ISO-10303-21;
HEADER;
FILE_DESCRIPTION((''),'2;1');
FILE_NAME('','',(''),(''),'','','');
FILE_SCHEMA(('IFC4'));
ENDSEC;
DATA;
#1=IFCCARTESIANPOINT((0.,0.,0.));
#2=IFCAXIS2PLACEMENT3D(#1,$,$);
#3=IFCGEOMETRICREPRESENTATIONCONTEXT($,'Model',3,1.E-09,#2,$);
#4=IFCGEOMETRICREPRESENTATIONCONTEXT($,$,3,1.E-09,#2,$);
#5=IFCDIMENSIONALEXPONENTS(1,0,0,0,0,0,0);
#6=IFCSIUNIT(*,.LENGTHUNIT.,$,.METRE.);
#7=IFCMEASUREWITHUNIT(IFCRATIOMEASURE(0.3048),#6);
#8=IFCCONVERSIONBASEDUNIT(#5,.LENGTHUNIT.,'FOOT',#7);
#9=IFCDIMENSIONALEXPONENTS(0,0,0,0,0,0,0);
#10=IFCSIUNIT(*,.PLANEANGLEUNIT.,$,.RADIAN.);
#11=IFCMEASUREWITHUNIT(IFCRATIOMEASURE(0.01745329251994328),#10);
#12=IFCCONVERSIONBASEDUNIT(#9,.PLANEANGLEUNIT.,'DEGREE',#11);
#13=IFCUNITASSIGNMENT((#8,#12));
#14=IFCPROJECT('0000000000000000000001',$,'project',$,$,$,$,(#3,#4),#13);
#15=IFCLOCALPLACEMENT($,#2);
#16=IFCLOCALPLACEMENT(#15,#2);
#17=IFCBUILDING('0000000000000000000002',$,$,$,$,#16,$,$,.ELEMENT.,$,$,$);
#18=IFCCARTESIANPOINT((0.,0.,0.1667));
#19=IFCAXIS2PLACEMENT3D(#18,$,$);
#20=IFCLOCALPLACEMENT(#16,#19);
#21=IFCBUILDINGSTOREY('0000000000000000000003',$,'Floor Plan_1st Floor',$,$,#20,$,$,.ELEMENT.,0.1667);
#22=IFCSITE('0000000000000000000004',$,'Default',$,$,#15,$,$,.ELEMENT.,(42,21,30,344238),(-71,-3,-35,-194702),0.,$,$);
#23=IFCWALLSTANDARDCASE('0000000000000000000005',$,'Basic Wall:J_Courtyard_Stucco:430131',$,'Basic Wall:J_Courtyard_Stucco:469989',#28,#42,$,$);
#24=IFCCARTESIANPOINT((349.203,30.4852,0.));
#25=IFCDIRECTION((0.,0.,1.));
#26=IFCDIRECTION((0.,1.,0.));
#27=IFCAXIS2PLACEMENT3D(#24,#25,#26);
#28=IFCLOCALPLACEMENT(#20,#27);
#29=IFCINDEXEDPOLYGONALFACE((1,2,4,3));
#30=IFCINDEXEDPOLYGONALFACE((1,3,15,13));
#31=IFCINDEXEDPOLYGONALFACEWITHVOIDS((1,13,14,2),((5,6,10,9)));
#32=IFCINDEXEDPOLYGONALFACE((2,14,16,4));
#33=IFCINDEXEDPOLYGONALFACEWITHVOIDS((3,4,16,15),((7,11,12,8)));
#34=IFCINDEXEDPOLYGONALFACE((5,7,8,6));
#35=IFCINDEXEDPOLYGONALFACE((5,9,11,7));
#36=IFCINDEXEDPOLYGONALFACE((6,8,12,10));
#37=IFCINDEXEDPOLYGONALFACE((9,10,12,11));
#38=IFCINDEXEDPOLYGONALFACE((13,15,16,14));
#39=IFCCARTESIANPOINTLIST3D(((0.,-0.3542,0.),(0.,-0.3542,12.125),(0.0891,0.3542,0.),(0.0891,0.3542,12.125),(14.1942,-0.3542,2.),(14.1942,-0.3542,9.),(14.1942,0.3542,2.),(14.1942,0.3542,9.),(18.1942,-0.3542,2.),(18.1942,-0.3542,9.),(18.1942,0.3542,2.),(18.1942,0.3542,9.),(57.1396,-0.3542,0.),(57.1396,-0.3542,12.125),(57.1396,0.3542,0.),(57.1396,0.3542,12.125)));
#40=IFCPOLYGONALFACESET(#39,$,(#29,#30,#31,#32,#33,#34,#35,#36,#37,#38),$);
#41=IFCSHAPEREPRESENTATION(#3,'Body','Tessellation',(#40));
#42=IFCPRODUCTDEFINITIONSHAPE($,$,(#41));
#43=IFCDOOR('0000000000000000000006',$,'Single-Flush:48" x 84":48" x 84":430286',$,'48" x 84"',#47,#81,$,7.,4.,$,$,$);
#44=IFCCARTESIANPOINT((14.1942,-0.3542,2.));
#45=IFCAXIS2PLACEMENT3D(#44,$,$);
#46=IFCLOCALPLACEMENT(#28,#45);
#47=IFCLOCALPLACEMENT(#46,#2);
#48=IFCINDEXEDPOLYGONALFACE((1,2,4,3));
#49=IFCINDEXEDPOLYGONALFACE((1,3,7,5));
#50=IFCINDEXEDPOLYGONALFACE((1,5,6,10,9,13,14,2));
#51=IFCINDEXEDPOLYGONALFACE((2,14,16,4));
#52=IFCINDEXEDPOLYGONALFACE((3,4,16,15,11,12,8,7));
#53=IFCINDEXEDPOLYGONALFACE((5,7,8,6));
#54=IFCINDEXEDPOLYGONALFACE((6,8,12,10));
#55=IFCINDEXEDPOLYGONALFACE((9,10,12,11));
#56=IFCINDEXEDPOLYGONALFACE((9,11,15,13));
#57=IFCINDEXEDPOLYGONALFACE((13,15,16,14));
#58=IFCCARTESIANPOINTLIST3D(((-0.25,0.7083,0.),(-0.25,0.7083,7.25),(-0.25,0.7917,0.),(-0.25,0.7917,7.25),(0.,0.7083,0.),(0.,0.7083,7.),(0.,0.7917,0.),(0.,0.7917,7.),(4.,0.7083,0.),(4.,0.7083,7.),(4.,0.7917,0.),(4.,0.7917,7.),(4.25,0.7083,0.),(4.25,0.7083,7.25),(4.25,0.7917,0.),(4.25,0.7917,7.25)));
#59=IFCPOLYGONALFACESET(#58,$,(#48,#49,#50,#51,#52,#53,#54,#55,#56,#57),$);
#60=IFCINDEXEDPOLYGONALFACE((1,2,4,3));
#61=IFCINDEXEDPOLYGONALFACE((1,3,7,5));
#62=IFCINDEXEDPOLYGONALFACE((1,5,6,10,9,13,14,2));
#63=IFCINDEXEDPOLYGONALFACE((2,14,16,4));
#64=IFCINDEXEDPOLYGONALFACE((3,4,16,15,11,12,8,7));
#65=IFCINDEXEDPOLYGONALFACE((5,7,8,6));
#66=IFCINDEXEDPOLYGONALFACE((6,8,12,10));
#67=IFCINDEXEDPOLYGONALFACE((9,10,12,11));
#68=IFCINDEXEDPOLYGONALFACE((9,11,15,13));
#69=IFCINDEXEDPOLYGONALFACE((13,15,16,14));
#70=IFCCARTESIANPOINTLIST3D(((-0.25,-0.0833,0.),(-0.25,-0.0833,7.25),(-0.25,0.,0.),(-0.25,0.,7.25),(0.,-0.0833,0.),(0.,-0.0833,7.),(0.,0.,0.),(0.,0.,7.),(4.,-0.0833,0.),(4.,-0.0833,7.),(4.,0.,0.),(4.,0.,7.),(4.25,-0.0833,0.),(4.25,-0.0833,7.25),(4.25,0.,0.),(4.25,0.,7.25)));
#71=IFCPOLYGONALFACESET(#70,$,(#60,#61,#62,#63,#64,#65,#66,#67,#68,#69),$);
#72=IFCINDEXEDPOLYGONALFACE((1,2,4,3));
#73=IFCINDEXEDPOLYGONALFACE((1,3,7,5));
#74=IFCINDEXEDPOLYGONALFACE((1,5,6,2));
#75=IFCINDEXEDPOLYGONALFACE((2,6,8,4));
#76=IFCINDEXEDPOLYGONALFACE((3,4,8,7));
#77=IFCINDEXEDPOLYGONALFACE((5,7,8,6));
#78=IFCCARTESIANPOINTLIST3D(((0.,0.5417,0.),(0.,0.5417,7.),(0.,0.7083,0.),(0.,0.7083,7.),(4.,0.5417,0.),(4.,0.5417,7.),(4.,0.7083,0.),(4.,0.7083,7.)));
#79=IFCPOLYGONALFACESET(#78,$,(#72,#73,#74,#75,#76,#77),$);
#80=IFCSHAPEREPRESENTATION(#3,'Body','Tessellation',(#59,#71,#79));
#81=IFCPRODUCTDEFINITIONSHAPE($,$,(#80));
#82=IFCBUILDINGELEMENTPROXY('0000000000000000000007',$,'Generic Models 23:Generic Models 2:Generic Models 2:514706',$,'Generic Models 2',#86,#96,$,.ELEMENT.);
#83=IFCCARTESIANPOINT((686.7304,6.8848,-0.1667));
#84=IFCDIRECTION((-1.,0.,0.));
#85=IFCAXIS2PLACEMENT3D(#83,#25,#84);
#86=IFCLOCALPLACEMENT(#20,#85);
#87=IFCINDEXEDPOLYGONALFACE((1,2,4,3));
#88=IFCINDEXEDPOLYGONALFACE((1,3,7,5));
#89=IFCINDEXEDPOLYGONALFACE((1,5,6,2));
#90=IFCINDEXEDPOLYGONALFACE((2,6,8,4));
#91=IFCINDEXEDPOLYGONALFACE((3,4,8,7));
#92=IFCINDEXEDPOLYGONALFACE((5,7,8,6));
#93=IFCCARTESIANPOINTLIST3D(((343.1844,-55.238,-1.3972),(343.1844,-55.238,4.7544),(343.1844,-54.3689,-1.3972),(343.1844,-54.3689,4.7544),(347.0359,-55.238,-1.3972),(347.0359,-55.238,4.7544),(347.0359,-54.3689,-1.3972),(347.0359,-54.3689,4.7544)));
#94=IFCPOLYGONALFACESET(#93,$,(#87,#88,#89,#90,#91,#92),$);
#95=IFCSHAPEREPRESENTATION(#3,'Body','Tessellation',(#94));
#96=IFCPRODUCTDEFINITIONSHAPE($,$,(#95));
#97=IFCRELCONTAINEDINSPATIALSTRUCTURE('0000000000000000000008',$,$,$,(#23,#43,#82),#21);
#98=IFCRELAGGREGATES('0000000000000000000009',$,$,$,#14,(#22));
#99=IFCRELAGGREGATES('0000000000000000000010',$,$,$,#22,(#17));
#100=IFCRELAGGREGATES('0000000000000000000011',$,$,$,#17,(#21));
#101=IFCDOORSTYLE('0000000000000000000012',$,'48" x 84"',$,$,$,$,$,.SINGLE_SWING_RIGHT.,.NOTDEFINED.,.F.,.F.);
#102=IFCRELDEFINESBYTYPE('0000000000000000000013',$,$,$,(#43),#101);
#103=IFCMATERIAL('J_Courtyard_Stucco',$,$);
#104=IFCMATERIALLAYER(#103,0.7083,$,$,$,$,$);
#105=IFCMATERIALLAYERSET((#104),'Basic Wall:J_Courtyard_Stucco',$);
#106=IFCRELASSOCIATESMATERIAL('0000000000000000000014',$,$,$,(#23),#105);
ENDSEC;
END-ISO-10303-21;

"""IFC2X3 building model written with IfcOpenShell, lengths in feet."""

from ifc_helpers import new_model, entity, si_unit, converted_unit, frame, frame_2d, origin, origin_2d_with_axis, place, context, project, spatial, polyline, rectangle, outline, extrude, clip, halfspace, source, transform, mapped, material, layer, layer_set, layer_usage, type_object, type_shapes, element, fill, save


model = new_model("IFC2X3")

# Units and contexts
model_context = context("Model", 3, precision=1e-09, world=origin())
context_of_model = context(None, 3, precision=1e-09, world=origin())
ifc_project = project(units=[converted_unit("LENGTHUNIT", "FOOT", entity("IfcRatioMeasure", 0.3048), si_unit("LENGTHUNIT", "METRE"), dimensions=[1, 0, 0, 0, 0, 0, 0]), converted_unit("PLANEANGLEUNIT", "DEGREE", entity("IfcRatioMeasure", 0.01745329251994328), si_unit("PLANEANGLEUNIT", "RADIAN"), dimensions=[0, 0, 0, 0, 0, 0, 0])], contexts=[model_context, context_of_model])

# Site, building, storey
site_placement = place(None, origin())
site = spatial("IfcSite", under=ifc_project, at=site_placement, Name="Default", CompositionType="ELEMENT", RefLatitude=(42, 21, 30, 344238), RefLongitude=(-71, -3, -35, -194702), RefElevation=0.0)
building_placement = place(site_placement, origin())
building = spatial("IfcBuilding", under=site, at=building_placement, CompositionType="ELEMENT")
storey_placement = place(building_placement, frame((0.0, 0.0, 0.1667)))
storey = spatial("IfcBuildingStorey", under=building, at=storey_placement, Name="Floor Plan_1st Floor", CompositionType="ELEMENT", Elevation=0.1667)

# Shared definitions
ifc_material_1 = material(Name="J_Courtyard_Stucco")
ifc_layer_1 = layer(ifc_material_1, 0.7083)
ifc_layer_set_1 = layer_set([ifc_layer_1], Name="Basic Wall:J_Courtyard_Stucco")

# Wall, opening, door
ifc_layer_usage_1 = layer_usage(ifc_layer_set_1, "AXIS2", "NEGATIVE", 0.3542)
wall_1_placement = place(storey_placement, frame((349.203, 30.4852, 0.0), z_axis=(0.0, 0.0, 1.0), x_axis=(0.0, 1.0, 0.0)))
wall_1 = element("IfcWallStandardCase", 1, at=wall_1_placement, inside=storey, material=ifc_layer_usage_1, Name="Basic Wall:J_Courtyard_Stucco:430131", ObjectType="Basic Wall:J_Courtyard_Stucco:469989", context=model_context, shape_type="Clipping", body=[
    clip(extrude(outline(polyline([(57.1396, -0.3542), (57.1396, 0.3542), (0.0891, 0.3542), (0.0, -0.3542), (57.1396, -0.3542)])), origin(), (0.0, 0.0, 1.0), 12.125), halfspace(origin(), True)),
])
opening_1_placement = place(wall_1_placement, frame((14.1942, -0.3542, 2.0)))
opening_1 = element("IfcOpeningElement", 2, at=opening_1_placement, cuts=wall_1, ObjectType="Opening", context=model_context, shape_type="SweptSolid", body=[
    extrude(rectangle(XDim=4.0, YDim=7.0, at=frame_2d((3.5, 2.0), x_axis=(0.0, 1.0))), frame((0.0, 0.0, 0.0), z_axis=(0.0, 1.0, 0.0), x_axis=(0.0, 0.0, 1.0)), (0.0, 0.0, 1.0), 0.7083),
])
door_style_1 = type_object("IfcDoorStyle", Name="48\" x 84\"", ConstructionType="NOTDEFINED", OperationType="SINGLE_SWING_RIGHT", ParameterTakesPrecedence=False, Sizeable=False)
shared_shape_1 = source(origin(), model_context, "Body", "SweptSolid", [
    extrude(outline(polyline([(-2.25, -3.6875), (2.25, -3.6875), (2.25, 3.5625), (2.0, 3.5625), (2.0, -3.4375), (-2.0, -3.4375), (-2.0, 3.5625), (-2.25, 3.5625), (-2.25, -3.6875)])), frame((2.0, 0.7083, 3.5625), z_axis=(0.0, 1.0, 0.0), x_axis=(1.0, 0.0, 0.0)), (0.0, 0.0, 1.0), 0.0833),
    extrude(outline(polyline([(-3.6875, -2.25), (3.5625, -2.25), (3.5625, -2.0), (-3.4375, -2.0), (-3.4375, 2.0), (3.5625, 2.0), (3.5625, 2.25), (-3.6875, 2.25), (-3.6875, -2.25)])), frame((2.0, -0.0833, 3.5625), z_axis=(0.0, 1.0, 0.0), x_axis=(0.0, 0.0, -1.0)), (0.0, 0.0, 1.0), 0.0833),
    extrude(rectangle(XDim=0.1667, YDim=4.0, at=origin_2d_with_axis()), frame((2.0, 0.625, 0.0), z_axis=(0.0, 0.0, 1.0), x_axis=(0.0, 1.0, 0.0)), (0.0, 0.0, 1.0), 7.0),
])
type_shapes(door_style_1, [shared_shape_1])
door_1_placement = place(opening_1_placement, origin())
door_1 = element("IfcDoor", 3, at=door_1_placement, inside=storey, type_object=door_style_1, Name="Single-Flush:48\" x 84\":48\" x 84\":430286", ObjectType="48\" x 84\"", OverallHeight=7.0, OverallWidth=4.0, context=model_context, shape_type="MappedRepresentation", body=[
    mapped(shared_shape_1, transform((0.0, 0.0, 0.0), scale=1.0)),
])
fill(opening_1, door_1)

# Building element proxy
shared_shape_2 = source(origin(), model_context, "Body", "SweptSolid", [
    extrude(rectangle(XDim=3.8516, YDim=0.8691, at=origin_2d_with_axis()), frame((345.1101, -54.8035, -1.3972)), (0.0, 0.0, 1.0), 6.1516),
])
proxy_placement = place(storey_placement, frame((686.7304, 6.8848, -0.1667), z_axis=(0.0, 0.0, 1.0), x_axis=(-1.0, 0.0, 0.0)))
element("IfcBuildingElementProxy", 4, at=proxy_placement, inside=storey, Name="Generic Models 23:Generic Models 2:Generic Models 2:514706", ObjectType="Generic Models 2", CompositionType="ELEMENT", context=model_context, shape_type="MappedRepresentation", body=[
    mapped(shared_shape_2, transform((0.0, 0.0, 0.0), scale=1.0)),
])

save(model, "model.ifc")
